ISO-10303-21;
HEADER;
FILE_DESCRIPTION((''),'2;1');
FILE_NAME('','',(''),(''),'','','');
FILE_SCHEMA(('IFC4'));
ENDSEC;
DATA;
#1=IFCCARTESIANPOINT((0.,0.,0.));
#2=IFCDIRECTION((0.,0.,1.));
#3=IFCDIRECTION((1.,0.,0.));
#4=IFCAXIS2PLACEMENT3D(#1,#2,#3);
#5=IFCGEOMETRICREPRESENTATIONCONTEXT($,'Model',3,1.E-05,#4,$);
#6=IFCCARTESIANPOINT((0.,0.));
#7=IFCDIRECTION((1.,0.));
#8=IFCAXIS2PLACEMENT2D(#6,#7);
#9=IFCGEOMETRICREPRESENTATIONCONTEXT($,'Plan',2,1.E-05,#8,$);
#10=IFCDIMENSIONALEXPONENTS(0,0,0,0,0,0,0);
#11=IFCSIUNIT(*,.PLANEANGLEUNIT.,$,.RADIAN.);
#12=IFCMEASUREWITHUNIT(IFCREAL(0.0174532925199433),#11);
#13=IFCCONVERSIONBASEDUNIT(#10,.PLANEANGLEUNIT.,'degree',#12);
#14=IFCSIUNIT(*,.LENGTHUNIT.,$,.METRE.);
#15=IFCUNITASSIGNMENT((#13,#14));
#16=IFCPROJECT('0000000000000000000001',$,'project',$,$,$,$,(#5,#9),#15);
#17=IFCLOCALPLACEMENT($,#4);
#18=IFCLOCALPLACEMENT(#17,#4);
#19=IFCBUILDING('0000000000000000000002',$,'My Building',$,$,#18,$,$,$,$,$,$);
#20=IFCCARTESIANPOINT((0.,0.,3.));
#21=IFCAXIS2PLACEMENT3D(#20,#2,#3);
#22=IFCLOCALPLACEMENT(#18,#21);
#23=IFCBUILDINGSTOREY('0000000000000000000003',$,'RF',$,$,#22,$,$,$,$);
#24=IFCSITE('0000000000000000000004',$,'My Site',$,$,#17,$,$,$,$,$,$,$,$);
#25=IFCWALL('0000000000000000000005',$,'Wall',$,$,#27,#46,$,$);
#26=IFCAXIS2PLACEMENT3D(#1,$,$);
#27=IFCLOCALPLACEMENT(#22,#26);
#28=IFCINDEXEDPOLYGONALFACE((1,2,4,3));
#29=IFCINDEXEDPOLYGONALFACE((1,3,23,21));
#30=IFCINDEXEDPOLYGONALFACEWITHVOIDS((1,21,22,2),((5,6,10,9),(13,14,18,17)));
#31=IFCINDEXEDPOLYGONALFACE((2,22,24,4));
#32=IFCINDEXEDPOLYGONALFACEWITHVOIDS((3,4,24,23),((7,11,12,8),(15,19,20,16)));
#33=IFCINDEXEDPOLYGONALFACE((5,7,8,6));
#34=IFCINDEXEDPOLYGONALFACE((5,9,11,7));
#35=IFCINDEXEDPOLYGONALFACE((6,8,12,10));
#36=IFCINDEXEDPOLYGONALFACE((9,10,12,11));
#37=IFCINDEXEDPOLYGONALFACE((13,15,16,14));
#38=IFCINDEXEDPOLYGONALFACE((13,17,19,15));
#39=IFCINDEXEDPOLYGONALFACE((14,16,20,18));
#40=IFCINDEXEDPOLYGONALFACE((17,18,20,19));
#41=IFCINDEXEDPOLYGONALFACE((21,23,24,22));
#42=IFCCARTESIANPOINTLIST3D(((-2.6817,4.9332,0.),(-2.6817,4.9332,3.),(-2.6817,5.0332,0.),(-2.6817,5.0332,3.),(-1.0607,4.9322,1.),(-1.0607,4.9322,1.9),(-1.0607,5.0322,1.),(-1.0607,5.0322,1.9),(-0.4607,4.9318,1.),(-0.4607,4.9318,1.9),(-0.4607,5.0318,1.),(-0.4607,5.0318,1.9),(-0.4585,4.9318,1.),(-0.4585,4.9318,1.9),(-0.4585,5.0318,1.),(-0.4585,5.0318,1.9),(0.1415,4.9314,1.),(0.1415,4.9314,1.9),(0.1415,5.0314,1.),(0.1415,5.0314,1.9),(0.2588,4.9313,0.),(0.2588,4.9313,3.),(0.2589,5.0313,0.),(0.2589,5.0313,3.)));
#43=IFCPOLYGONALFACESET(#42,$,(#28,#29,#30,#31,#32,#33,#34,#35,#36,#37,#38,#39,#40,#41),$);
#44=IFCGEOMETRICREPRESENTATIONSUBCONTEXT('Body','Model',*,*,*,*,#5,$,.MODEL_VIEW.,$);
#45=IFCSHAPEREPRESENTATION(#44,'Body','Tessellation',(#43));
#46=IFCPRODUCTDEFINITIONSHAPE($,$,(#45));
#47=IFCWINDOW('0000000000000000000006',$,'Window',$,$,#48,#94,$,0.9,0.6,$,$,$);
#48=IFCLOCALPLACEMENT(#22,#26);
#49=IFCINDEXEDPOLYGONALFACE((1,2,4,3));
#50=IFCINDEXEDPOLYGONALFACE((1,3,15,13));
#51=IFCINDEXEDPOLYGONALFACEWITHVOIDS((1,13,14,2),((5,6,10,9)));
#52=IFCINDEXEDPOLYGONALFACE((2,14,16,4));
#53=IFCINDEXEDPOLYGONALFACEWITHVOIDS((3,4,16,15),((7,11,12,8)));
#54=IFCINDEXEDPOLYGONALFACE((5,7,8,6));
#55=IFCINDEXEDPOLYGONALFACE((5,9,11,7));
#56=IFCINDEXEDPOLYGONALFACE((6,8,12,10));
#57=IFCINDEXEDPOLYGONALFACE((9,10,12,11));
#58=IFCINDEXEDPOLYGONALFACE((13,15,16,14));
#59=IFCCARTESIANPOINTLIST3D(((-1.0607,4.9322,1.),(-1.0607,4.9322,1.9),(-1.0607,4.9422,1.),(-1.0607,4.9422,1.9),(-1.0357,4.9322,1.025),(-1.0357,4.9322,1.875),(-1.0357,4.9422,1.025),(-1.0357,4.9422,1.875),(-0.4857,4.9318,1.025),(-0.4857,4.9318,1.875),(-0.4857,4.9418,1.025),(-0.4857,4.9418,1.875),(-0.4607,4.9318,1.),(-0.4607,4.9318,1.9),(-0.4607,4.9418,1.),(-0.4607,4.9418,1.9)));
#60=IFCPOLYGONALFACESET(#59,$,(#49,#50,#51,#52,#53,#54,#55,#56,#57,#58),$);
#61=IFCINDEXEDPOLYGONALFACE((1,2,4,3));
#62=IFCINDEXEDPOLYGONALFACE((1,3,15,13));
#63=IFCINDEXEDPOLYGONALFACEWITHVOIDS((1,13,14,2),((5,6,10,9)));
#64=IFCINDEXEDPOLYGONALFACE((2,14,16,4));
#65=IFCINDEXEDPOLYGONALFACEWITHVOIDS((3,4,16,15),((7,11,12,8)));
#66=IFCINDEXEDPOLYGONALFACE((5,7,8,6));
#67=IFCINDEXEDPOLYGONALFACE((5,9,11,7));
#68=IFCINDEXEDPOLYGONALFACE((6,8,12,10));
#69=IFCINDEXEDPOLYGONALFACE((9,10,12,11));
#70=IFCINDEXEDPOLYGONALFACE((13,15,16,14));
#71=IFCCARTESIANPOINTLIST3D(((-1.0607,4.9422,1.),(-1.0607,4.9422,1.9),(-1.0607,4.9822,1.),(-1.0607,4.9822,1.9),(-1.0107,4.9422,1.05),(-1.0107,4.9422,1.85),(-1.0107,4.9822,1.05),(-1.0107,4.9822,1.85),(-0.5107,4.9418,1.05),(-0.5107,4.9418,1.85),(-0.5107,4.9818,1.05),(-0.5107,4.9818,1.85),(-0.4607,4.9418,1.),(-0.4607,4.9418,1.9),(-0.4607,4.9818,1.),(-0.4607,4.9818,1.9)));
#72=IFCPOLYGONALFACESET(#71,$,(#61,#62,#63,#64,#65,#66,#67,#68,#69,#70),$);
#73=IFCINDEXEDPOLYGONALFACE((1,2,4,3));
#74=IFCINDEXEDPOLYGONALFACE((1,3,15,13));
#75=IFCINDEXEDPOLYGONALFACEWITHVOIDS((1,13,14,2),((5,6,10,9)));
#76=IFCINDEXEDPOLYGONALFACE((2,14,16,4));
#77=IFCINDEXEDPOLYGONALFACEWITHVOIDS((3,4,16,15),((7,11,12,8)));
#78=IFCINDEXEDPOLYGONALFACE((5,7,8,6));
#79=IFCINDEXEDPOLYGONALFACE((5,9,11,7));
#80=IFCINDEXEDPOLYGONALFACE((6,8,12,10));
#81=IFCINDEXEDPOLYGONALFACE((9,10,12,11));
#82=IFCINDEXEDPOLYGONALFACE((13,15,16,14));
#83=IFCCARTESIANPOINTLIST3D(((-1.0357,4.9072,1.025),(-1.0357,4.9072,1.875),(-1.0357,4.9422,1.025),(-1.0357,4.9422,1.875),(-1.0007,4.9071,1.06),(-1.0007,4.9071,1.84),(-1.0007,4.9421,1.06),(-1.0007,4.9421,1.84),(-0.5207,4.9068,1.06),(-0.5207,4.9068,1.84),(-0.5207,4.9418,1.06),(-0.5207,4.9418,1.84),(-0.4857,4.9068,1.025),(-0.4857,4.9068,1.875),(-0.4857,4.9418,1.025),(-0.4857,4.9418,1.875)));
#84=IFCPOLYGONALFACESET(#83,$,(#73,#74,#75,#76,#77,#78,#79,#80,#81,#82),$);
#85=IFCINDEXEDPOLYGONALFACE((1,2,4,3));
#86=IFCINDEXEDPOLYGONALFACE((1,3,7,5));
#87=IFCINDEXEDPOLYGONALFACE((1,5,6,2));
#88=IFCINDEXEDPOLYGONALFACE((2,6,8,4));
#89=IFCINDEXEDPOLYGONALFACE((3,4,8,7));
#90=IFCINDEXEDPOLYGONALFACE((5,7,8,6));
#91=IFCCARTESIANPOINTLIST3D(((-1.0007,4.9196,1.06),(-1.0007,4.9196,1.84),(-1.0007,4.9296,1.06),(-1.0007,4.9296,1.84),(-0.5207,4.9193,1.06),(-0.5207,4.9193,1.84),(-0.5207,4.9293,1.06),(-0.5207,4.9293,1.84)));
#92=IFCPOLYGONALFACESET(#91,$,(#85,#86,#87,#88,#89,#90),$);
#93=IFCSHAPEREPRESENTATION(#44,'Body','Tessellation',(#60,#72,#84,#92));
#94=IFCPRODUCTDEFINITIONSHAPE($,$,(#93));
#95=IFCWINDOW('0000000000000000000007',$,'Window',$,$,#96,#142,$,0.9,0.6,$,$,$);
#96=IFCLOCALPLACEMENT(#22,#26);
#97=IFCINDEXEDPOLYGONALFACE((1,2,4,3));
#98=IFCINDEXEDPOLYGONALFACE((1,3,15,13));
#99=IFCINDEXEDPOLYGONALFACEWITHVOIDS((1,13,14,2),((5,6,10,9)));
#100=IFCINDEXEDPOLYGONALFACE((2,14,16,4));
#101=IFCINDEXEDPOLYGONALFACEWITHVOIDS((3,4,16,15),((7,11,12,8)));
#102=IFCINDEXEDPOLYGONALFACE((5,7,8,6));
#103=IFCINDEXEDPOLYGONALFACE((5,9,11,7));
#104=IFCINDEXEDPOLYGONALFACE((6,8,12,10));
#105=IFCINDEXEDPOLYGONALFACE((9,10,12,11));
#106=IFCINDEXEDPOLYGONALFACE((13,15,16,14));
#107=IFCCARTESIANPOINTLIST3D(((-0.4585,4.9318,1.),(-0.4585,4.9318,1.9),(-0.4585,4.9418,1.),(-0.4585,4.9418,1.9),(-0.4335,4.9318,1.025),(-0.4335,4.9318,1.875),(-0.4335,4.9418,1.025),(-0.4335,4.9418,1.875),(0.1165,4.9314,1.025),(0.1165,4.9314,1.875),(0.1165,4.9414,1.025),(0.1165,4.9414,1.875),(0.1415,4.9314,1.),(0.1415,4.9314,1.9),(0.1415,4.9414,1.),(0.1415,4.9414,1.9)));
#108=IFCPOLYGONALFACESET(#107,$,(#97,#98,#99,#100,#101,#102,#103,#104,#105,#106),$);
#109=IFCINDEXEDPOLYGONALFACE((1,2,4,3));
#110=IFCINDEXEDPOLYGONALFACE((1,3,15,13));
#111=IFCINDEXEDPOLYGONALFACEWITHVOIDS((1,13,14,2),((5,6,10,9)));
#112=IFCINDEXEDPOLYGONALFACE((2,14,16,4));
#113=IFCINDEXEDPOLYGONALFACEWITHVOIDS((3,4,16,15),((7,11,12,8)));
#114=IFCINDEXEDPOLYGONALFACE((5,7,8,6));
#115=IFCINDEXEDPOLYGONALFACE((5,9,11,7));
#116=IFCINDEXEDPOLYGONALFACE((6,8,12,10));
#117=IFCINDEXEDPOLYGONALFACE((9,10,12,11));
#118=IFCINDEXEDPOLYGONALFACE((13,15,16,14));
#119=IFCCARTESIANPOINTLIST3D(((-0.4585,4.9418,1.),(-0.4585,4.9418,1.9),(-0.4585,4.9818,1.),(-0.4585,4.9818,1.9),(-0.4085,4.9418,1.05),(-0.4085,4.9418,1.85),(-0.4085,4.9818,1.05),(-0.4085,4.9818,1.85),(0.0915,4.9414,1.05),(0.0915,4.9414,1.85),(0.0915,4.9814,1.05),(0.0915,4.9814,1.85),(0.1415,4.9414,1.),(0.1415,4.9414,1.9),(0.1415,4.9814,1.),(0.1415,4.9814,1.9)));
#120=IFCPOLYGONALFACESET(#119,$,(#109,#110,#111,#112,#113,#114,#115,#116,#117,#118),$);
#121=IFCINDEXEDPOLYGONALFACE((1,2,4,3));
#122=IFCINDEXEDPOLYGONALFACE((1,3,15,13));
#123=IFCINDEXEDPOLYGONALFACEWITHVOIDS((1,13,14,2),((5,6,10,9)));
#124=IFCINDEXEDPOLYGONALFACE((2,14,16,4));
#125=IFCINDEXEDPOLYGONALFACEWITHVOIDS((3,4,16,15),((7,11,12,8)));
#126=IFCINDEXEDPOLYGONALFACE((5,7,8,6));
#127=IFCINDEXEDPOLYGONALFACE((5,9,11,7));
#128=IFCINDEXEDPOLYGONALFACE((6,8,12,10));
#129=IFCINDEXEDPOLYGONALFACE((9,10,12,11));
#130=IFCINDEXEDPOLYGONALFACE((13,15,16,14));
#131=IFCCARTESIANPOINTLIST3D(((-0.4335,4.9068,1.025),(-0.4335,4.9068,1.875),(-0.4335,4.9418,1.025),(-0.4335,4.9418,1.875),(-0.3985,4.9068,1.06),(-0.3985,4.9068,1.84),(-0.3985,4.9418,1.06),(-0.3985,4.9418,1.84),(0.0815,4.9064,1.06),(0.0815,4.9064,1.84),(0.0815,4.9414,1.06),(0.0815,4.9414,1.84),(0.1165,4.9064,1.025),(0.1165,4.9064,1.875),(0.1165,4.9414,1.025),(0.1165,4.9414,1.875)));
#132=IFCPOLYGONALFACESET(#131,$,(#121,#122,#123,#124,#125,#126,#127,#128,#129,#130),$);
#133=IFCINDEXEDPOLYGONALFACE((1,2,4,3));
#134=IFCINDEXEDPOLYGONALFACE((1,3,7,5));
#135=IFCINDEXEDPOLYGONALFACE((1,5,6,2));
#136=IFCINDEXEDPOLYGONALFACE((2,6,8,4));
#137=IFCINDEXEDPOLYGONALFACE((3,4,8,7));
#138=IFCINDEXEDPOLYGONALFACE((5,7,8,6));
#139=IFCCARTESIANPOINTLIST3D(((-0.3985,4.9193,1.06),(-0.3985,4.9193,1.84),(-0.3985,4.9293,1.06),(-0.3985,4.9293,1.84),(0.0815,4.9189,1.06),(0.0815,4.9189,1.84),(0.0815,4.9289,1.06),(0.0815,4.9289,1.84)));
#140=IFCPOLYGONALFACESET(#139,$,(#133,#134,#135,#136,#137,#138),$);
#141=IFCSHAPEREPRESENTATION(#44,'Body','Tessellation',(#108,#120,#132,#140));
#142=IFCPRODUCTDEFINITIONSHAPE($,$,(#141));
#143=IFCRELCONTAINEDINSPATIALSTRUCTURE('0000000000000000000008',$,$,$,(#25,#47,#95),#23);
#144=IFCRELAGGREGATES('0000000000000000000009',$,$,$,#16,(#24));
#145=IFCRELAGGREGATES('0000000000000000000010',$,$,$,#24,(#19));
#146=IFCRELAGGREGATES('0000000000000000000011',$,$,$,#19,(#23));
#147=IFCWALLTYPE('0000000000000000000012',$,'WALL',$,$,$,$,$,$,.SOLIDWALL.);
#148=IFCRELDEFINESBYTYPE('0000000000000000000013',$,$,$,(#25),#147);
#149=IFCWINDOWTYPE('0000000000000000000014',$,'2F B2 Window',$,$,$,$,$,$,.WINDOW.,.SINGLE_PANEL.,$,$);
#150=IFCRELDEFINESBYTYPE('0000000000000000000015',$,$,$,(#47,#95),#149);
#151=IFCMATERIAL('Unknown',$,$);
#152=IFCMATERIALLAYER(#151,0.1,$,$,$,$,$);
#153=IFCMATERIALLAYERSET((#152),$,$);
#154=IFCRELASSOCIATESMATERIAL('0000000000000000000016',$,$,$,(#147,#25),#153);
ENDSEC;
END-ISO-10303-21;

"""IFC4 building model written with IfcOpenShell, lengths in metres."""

from ifc_helpers import new_model, entity, si_unit, converted_unit, frame, origin_with_axes, origin_2d_with_axis, place, context, subcontext, project, spatial, line, indexed_curve, outline, extrude, shape, source, transform, mapped, material, layer, layer_set, layer_usage, type_object, type_shapes, element, fill, save


model = new_model("IFC4")

# Units and contexts
model_context = context("Model", 3, precision=1e-05, world=origin_with_axes())
plan_context = context("Plan", 2, precision=1e-05, world=origin_2d_with_axis())
body_context_1 = subcontext(model_context, "Body", "Model", "MODEL_VIEW")
body_context_2 = subcontext(plan_context, "Body", "Plan", "PLAN_VIEW")
ifc_project = project(units=[converted_unit("PLANEANGLEUNIT", "degree", entity("IfcReal", 0.0174532925199433), si_unit("PLANEANGLEUNIT", "RADIAN"), dimensions=[0, 0, 0, 0, 0, 0, 0]), si_unit("LENGTHUNIT", "METRE")], contexts=[model_context, plan_context])

# Site, building, storey
site_placement = place(None, origin_with_axes())
site = spatial("IfcSite", under=ifc_project, at=site_placement, Name="My Site")
building_placement = place(site_placement, origin_with_axes())
building = spatial("IfcBuilding", under=site, at=building_placement, Name="My Building")
storey_placement = place(building_placement, frame((0.0, 0.0, 3.0), z_axis=(0.0, 0.0, 1.0), x_axis=(1.0, 0.0, 0.0)))
storey = spatial("IfcBuildingStorey", under=building, at=storey_placement, Name="RF")

# Wall, openings, windows
ifc_material = material(Name="Unknown")
ifc_layer = layer(ifc_material, 0.1)
ifc_layer_set = layer_set([ifc_layer])
ifc_layer_usage = layer_usage(ifc_layer_set, "AXIS2", "POSITIVE", 0.0)
wall_type = type_object("IfcWallType", Name="WALL", PredefinedType="SOLIDWALL", material=ifc_layer_set)
wall_placement = place(storey_placement, frame((0.2589, 5.0313, 0.0), z_axis=(0.0, 0.0, 1.0), x_axis=(-1.0, 0.000645, 0.0)))
wall = element("IfcWall", 1, at=wall_placement, inside=storey, type_object=wall_type, material=ifc_layer_usage, Name="Wall", context=body_context_1, shape_type="SweptSolid", body=[
    extrude(outline(indexed_curve([(0.0, 0.0), (0.0, 0.1), (2.9405, 0.1), (2.9405, 0.0)], segments=[line(1, 2, 3, 4, 1)])), origin_with_axes(), (0.0, 0.0, 1.0), 3.0),
])
shared_shape_1 = source(origin_with_axes(), body_context_1, "Body", "SweptSolid", [
    extrude(outline(indexed_curve([(0.0, 0.0), (0.6, 0.0), (0.6, 0.9), (0.0, 0.9)], segments=[line(1, 2, 3, 4, 1)])), frame((0.0, -0.6, 0.0), z_axis=(0.0, -1.0, 0.0), x_axis=(1.0, 0.0, 0.0)), (0.0, 0.0, -1.0), 1.2),
])
opening_1_placement = place(wall_placement, frame((0.7195, 0.0, 1.0), z_axis=(0.0, 0.0, 1.0), x_axis=(1.0, 0.0, 0.0)))
opening_1 = element("IfcOpeningElement", 2, at=opening_1_placement, cuts=wall, PredefinedType="OPENING", context=body_context_1, shape_type="MappedRepresentation", body=[
    mapped(shared_shape_1, transform((0.0, 0.0, 0.0), x_axis=(1.0, 0.0, 0.0), y_axis=(0.0, 1.0, 0.0), z_axis=(0.0, 0.0, 1.0), scale=1.0)),
])
opening_2_placement = place(wall_placement, frame((0.1173, 0.0, 1.0), z_axis=(0.0, 0.0, 1.0), x_axis=(1.0, 0.0, 0.0)))
opening_2 = element("IfcOpeningElement", 3, at=opening_2_placement, cuts=wall, PredefinedType="OPENING", context=body_context_1, shape_type="MappedRepresentation", body=[
    mapped(shared_shape_1, transform((0.0, 0.0, 0.0), x_axis=(1.0, 0.0, 0.0), y_axis=(0.0, 1.0, 0.0), z_axis=(0.0, 0.0, 1.0), scale=1.0)),
])
window_type = type_object("IfcWindowType", Name="2F B2 Window", PartitioningType="SINGLE_PANEL", PredefinedType="WINDOW")
shared_shape_2 = source(origin_with_axes(), body_context_1, "Body", "SweptSolid", [
    extrude(outline(indexed_curve([(0.0, 0.0), (0.6, 0.0), (0.6, 0.9), (0.0, 0.9)], segments=[line(1, 2, 3, 4, 1)]), holes=[indexed_curve([(0.025, 0.025), (0.575, 0.025), (0.575, 0.875), (0.025, 0.875)], segments=[line(1, 2, 3, 4, 1)])]), frame((0.0, 0.09, 0.0), z_axis=(0.0, -1.0, 0.0), x_axis=(1.0, 0.0, 0.0)), (0.0, 0.0, -1.0), 0.01),
    extrude(outline(indexed_curve([(0.0, 0.0), (0.6, 0.0), (0.6, 0.9), (0.0, 0.9)], segments=[line(1, 2, 3, 4, 1)]), holes=[indexed_curve([(0.05, 0.05), (0.55, 0.05), (0.55, 0.85), (0.05, 0.85)], segments=[line(1, 2, 3, 4, 1)])]), frame((0.0, 0.05, 0.0), z_axis=(0.0, -1.0, 0.0), x_axis=(1.0, 0.0, 0.0)), (0.0, 0.0, -1.0), 0.04),
    extrude(outline(indexed_curve([(0.0, 0.0), (0.55, 0.0), (0.55, 0.85), (0.0, 0.85)], segments=[line(1, 2, 3, 4, 1)]), holes=[indexed_curve([(0.035, 0.035), (0.515, 0.035), (0.515, 0.815), (0.035, 0.815)], segments=[line(1, 2, 3, 4, 1)])]), frame((0.025, 0.09, 0.025), z_axis=(0.0, -1.0, 0.0), x_axis=(1.0, 0.0, 0.0)), (0.0, 0.0, -1.0), 0.035),
    extrude(outline(indexed_curve([(0.035, 0.035), (0.515, 0.035), (0.515, 0.815), (0.035, 0.815)], segments=[line(1, 2, 3, 4, 1)])), frame((0.025, 0.1025, 0.025), z_axis=(0.0, -1.0, 0.0), x_axis=(1.0, 0.0, 0.0)), (0.0, 0.0, -1.0), 0.01),
])
shared_shape_3 = source(origin_with_axes(), body_context_2, "Body", "Curve2D", [
    entity("IfcIndexedPolyCurve", entity("IfcCartesianPointList2D", [[0.05, 0.05], [0.55, 0.05]])),
    entity("IfcIndexedPolyCurve", entity("IfcCartesianPointList2D", [[0.0, 0.1], [0.025, 0.1], [0.025, 0.09], [0.05, 0.09], [0.05, 0.05], [0.0, 0.05]]), [entity("IfcLineIndex", [1, 2, 3, 4, 5, 6, 1])]),
    entity("IfcIndexedPolyCurve", entity("IfcCartesianPointList2D", [[0.6, 0.1], [0.575, 0.1], [0.575, 0.09], [0.55, 0.09], [0.55, 0.05], [0.6, 0.05]]), [entity("IfcLineIndex", [1, 2, 3, 4, 5, 6, 1])]),
    entity("IfcIndexedPolyCurve", entity("IfcCartesianPointList2D", [[0.025, 0.09], [0.06, 0.09], [0.06, 0.125], [0.025, 0.125]]), [entity("IfcLineIndex", [1, 2, 3, 4, 1])]),
    entity("IfcIndexedPolyCurve", entity("IfcCartesianPointList2D", [[0.575, 0.09], [0.54, 0.09], [0.54, 0.125], [0.575, 0.125]]), [entity("IfcLineIndex", [1, 2, 3, 4, 1])]),
    entity("IfcIndexedPolyCurve", entity("IfcCartesianPointList2D", [[0.06, 0.09], [0.54, 0.09]])),
    entity("IfcIndexedPolyCurve", entity("IfcCartesianPointList2D", [[0.06, 0.125], [0.54, 0.125]])),
    entity("IfcIndexedPolyCurve", entity("IfcCartesianPointList2D", [[0.06, 0.1075], [0.54, 0.1075]])),
])
type_shapes(window_type, [shared_shape_2, shared_shape_3])
window_1_placement = place(opening_1_placement, frame((0.0, 0.0, 0.0), z_axis=(0.0, 0.0, 1.0), x_axis=(1.0, 0.0, 0.0)))
window_1 = element("IfcWindow", 4, at=window_1_placement, inside=storey, type_object=window_type, Name="Window", OverallHeight=0.9, OverallWidth=0.6, shapes=[
    shape(body_context_1, "Body", "MappedRepresentation", [mapped(shared_shape_2, transform((0.0, 0.0, 0.0), x_axis=(1.0, 0.0, 0.0), y_axis=(0.0, 1.0, 0.0), z_axis=(0.0, 0.0, 1.0), scale=1.0))]),
    shape(body_context_2, "Body", "MappedRepresentation", [mapped(shared_shape_3, transform((0.0, 0.0, 0.0), x_axis=(1.0, 0.0, 0.0), y_axis=(0.0, 1.0, 0.0), z_axis=(0.0, 0.0, 1.0), scale=1.0))]),
])
fill(opening_1, window_1)
window_2_placement = place(opening_2_placement, frame((0.0, 0.0, 0.0), z_axis=(0.0, 0.0, 1.0), x_axis=(1.0, 0.0, 0.0)))
window_2 = element("IfcWindow", 5, at=window_2_placement, inside=storey, type_object=window_type, Name="Window", OverallHeight=0.9, OverallWidth=0.6, shapes=[
    shape(body_context_1, "Body", "MappedRepresentation", [mapped(shared_shape_2, transform((0.0, 0.0, 0.0), x_axis=(1.0, 0.0, 0.0), y_axis=(0.0, 1.0, 0.0), z_axis=(0.0, 0.0, 1.0), scale=1.0))]),
    shape(body_context_2, "Body", "MappedRepresentation", [mapped(shared_shape_3, transform((0.0, 0.0, 0.0), x_axis=(1.0, 0.0, 0.0), y_axis=(0.0, 1.0, 0.0), z_axis=(0.0, 0.0, 1.0), scale=1.0))]),
])
fill(opening_2, window_2)

save(model, "model.ifc")
